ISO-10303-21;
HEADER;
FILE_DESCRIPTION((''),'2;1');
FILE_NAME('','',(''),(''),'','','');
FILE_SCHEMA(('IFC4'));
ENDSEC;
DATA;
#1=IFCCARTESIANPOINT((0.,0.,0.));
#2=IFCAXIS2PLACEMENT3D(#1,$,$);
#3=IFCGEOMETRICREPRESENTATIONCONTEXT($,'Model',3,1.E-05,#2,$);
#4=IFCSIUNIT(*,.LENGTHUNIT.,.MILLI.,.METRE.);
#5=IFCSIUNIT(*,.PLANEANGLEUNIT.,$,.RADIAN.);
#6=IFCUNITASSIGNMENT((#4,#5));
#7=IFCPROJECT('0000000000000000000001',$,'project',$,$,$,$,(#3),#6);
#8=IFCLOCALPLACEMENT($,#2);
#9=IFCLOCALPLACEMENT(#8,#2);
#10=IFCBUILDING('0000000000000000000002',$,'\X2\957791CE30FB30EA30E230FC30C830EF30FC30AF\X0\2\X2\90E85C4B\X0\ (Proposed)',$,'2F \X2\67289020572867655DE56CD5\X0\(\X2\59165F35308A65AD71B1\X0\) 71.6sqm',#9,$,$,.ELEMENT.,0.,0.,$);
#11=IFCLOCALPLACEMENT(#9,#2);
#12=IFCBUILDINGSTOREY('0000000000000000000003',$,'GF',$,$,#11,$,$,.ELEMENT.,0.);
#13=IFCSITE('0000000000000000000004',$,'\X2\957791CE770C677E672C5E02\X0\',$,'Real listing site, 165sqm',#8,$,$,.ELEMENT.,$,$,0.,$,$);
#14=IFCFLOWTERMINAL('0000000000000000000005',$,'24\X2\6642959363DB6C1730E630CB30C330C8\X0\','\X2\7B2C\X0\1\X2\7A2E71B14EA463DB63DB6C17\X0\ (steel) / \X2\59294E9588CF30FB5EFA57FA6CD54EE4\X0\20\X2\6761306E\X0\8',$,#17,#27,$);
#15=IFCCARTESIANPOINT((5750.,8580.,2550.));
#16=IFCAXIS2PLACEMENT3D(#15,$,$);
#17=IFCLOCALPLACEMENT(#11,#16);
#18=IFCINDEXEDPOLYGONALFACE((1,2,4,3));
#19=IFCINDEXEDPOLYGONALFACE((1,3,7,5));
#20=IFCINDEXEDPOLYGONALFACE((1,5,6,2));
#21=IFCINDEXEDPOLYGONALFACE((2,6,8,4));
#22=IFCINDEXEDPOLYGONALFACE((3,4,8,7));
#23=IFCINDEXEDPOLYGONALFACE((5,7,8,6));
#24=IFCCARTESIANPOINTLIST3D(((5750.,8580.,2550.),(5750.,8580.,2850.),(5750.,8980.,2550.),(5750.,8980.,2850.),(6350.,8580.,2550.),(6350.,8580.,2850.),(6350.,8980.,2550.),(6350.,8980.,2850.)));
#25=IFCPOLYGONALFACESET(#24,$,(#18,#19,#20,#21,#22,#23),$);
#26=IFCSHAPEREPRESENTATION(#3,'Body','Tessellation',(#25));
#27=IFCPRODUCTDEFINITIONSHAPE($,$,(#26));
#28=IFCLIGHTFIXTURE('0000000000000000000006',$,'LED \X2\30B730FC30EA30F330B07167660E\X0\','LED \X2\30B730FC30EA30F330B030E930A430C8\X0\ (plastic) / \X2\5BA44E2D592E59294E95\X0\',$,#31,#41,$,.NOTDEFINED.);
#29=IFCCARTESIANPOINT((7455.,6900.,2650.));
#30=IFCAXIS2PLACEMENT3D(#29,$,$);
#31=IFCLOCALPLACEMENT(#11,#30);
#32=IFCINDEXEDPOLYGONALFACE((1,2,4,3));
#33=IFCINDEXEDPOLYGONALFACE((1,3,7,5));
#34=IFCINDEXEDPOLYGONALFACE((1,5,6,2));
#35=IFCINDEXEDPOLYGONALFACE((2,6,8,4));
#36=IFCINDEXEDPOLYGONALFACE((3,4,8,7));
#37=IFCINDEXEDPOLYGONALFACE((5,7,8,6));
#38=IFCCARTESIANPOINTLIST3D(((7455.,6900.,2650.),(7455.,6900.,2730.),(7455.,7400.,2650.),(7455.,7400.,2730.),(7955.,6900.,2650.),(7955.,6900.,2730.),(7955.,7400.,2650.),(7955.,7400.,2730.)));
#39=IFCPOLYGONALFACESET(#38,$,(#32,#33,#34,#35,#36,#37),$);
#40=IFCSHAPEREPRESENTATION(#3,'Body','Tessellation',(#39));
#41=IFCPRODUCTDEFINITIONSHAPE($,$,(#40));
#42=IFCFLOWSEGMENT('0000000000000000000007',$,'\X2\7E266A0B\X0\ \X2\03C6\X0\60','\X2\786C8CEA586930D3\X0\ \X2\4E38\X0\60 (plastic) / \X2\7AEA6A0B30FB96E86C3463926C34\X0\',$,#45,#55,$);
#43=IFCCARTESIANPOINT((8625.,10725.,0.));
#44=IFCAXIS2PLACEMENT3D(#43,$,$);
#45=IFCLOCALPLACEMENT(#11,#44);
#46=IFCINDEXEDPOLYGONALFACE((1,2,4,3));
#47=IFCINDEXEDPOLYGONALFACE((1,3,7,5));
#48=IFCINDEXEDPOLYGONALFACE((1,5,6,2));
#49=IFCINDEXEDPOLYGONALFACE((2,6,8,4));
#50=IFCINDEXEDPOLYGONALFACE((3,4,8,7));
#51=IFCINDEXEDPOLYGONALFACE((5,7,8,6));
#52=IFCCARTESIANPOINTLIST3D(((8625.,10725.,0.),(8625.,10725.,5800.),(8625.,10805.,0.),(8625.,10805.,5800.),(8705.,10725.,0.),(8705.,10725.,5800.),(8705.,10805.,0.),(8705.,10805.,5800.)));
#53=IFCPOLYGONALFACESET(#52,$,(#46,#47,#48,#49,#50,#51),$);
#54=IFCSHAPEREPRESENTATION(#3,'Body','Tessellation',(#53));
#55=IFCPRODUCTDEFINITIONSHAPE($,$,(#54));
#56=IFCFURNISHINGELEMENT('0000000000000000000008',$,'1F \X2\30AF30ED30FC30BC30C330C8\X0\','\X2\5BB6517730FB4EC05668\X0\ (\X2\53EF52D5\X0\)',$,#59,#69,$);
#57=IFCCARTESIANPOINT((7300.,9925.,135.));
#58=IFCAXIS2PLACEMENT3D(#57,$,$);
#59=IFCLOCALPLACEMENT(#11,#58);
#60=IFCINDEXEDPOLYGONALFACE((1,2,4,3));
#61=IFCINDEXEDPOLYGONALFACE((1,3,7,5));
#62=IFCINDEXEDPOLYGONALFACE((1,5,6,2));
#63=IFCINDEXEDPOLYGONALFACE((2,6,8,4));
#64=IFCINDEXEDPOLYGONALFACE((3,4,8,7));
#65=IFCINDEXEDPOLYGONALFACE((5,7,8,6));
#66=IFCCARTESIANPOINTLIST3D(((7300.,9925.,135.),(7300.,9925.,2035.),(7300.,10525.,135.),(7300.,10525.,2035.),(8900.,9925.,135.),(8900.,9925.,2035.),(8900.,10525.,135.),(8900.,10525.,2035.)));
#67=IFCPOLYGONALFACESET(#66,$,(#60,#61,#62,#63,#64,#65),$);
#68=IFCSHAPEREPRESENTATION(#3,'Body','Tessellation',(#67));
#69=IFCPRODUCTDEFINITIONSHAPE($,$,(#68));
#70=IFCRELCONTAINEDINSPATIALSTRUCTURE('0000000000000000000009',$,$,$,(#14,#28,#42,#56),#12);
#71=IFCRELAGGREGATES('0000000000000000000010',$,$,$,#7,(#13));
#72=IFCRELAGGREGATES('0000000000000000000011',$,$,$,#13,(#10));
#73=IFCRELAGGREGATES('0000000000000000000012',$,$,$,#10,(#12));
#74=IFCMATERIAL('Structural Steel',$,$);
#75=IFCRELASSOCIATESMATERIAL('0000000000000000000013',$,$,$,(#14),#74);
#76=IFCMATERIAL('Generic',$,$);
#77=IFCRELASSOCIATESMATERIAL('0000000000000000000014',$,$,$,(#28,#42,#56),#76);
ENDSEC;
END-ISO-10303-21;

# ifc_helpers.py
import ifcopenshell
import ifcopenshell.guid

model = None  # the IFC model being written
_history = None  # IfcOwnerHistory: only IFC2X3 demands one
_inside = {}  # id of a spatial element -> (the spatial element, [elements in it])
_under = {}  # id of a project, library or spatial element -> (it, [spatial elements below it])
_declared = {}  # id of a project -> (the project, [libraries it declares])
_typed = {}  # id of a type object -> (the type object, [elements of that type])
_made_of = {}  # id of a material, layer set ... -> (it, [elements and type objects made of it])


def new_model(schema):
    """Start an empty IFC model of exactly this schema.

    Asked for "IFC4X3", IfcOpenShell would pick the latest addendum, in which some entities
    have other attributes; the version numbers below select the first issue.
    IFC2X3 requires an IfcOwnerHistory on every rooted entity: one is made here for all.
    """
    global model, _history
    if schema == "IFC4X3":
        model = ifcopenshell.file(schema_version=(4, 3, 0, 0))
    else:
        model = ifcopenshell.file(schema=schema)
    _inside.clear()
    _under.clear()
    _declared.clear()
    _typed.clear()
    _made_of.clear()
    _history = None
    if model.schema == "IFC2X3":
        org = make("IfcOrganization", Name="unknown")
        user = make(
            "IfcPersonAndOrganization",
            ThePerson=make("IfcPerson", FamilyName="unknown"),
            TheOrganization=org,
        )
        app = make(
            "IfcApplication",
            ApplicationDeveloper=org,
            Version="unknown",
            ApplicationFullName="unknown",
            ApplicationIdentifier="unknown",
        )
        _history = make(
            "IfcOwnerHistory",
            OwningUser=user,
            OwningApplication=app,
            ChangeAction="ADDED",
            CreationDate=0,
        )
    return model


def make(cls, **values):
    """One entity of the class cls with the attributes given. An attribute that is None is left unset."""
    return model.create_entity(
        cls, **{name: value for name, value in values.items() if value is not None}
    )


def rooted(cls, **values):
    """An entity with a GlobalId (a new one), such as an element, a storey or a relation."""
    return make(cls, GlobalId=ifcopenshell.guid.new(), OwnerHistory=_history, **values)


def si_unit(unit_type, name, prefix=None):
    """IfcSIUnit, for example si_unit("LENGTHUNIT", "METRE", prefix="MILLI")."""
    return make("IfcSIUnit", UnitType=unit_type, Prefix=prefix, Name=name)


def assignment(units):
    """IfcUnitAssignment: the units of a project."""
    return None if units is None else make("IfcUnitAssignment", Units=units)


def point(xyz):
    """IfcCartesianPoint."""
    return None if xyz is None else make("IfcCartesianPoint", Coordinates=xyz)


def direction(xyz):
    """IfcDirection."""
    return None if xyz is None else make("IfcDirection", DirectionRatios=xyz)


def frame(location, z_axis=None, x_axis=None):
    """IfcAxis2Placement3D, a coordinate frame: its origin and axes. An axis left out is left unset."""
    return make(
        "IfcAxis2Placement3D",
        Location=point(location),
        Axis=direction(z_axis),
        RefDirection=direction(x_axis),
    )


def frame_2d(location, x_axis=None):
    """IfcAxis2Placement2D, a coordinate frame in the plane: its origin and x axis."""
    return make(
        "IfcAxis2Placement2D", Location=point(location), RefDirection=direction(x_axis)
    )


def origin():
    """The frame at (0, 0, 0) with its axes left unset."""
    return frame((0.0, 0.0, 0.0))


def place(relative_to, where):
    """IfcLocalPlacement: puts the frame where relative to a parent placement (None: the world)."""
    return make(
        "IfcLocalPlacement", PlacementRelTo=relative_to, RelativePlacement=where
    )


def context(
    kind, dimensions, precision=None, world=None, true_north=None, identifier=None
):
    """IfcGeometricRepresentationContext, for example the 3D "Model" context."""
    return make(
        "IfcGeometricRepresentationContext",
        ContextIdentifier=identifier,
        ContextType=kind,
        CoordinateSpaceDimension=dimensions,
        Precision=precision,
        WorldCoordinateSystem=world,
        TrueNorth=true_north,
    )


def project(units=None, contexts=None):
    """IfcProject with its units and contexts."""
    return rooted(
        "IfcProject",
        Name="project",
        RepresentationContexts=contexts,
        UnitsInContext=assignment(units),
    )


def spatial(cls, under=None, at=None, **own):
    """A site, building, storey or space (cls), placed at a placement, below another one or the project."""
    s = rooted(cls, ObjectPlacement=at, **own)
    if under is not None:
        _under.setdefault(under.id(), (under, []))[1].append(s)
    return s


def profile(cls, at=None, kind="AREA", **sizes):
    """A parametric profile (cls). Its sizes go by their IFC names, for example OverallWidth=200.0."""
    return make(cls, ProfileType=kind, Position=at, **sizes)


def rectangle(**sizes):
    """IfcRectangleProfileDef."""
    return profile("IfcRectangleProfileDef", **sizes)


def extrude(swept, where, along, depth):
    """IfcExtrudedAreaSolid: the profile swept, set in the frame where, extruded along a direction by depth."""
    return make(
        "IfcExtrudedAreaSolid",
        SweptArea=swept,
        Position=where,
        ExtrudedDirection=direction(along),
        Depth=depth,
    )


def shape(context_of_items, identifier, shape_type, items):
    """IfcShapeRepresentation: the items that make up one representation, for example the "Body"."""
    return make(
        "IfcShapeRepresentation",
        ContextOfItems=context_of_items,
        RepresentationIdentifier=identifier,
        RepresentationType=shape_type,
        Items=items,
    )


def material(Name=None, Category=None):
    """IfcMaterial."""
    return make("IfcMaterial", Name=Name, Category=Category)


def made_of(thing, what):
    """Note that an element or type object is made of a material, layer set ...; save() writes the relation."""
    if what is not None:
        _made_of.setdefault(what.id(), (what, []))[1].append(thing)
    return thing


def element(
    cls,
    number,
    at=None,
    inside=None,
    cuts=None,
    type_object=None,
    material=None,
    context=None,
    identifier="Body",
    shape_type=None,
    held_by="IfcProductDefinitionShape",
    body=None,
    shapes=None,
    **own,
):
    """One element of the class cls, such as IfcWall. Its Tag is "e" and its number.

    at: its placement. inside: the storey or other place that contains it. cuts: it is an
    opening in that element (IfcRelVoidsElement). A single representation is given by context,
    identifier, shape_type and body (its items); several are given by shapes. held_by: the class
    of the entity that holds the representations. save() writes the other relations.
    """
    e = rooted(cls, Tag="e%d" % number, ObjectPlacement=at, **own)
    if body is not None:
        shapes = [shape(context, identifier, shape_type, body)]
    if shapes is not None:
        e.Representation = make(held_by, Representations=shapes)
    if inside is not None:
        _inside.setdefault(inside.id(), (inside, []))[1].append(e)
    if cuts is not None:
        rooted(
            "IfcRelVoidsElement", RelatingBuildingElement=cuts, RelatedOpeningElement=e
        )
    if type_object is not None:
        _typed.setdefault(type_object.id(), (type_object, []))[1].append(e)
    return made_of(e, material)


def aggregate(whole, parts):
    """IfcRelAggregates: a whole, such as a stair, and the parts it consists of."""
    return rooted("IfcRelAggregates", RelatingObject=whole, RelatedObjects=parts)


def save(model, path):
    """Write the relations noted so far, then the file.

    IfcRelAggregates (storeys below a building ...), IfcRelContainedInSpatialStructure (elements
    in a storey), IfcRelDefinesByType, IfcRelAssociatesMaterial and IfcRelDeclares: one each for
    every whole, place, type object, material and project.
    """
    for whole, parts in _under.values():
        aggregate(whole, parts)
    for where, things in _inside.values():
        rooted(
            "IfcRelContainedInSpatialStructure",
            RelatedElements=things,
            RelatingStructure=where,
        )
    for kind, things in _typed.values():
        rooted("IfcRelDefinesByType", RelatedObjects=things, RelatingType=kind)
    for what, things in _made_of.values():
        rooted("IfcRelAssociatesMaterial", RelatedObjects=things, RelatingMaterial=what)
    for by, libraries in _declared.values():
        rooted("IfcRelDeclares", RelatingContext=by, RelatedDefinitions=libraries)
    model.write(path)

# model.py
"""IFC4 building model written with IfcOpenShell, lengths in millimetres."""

from ifc_helpers import new_model, si_unit, frame, frame_2d, origin, place, context, project, spatial, rectangle, extrude, material, element, save


model = new_model("IFC4")

# Units and contexts
model_context = context("Model", 3, precision=1e-05, world=origin())
ifc_project = project(units=[si_unit("LENGTHUNIT", "METRE", prefix="MILLI"), si_unit("PLANEANGLEUNIT", "RADIAN")], contexts=[model_context])

# Site, building, storey
site_placement = place(None, origin())
site = spatial("IfcSite", under=ifc_project, at=site_placement, Name="長野県松本市", ObjectType="Real listing site, 165sqm", CompositionType="ELEMENT", RefElevation=0.0)
building_placement = place(site_placement, origin())
building = spatial("IfcBuilding", under=site, at=building_placement, Name="長野・リモートワーク2部屋 (Proposed)", ObjectType="2F 木造在来工法(外張り断熱) 71.6sqm", CompositionType="ELEMENT", ElevationOfRefHeight=0.0, ElevationOfTerrain=0.0)
storey_placement = place(building_placement, origin())
storey = spatial("IfcBuildingStorey", under=building, at=storey_placement, Name="GF", CompositionType="ELEMENT", Elevation=0.0)

# Shared definitions
ifc_material_1 = material(Name="Generic")

# Flow terminal
ifc_material_2 = material(Name="Structural Steel")
flow_terminal_placement = place(storey_placement, frame((5750.0, 8580.0, 2550.0)))
element("IfcFlowTerminal", 1, at=flow_terminal_placement, inside=storey, material=ifc_material_2, Name="24時間換気ユニット", Description="第1種熱交換換気 (steel) / 天井裏・建基法令20条の8", context=model_context, shape_type="SweptSolid", body=[
    extrude(rectangle(XDim=600.0, YDim=400.0, at=frame_2d((300.0, 200.0))), frame((5750.0, 8580.0, 2550.0)), (0.0, 0.0, 1.0), 300.0),
])

# Light fixture
light_fixture_placement = place(storey_placement, frame((7455.0, 6900.0, 2650.0)))
element("IfcLightFixture", 2, at=light_fixture_placement, inside=storey, material=ifc_material_1, Name="LED シーリング照明", Description="LED シーリングライト (plastic) / 室中央天井", PredefinedType="NOTDEFINED", context=model_context, shape_type="SweptSolid", body=[
    extrude(rectangle(XDim=500.0, YDim=500.0, at=frame_2d((250.0, 250.0))), frame((7455.0, 6900.0, 2650.0)), (0.0, 0.0, 1.0), 80.0),
])

# Flow segment
flow_segment_placement = place(storey_placement, frame((8625.0, 10725.0, 0.0)))
element("IfcFlowSegment", 3, at=flow_segment_placement, inside=storey, material=ifc_material_1, Name="縦樋 φ60", Description="硬質塩ビ 丸60 (plastic) / 竪樋・雨水排水", context=model_context, shape_type="SweptSolid", body=[
    extrude(rectangle(XDim=80.0, YDim=80.0, at=frame_2d((40.0, 40.0))), frame((8625.0, 10725.0, 0.0)), (0.0, 0.0, 1.0), 5800.0),
])

# Furnishing element
furnishing_placement = place(storey_placement, frame((7300.0, 9925.0, 135.0)))
element("IfcFurnishingElement", 4, at=furnishing_placement, inside=storey, material=ifc_material_1, Name="1F クローゼット", Description="家具・什器 (可動)", context=model_context, shape_type="SweptSolid", body=[
    extrude(rectangle(XDim=1600.0, YDim=600.0, at=frame_2d((800.0, 300.0))), frame((7300.0, 9925.0, 135.0)), (0.0, 0.0, 1.0), 1900.0),
])

save(model, "model.ifc")
